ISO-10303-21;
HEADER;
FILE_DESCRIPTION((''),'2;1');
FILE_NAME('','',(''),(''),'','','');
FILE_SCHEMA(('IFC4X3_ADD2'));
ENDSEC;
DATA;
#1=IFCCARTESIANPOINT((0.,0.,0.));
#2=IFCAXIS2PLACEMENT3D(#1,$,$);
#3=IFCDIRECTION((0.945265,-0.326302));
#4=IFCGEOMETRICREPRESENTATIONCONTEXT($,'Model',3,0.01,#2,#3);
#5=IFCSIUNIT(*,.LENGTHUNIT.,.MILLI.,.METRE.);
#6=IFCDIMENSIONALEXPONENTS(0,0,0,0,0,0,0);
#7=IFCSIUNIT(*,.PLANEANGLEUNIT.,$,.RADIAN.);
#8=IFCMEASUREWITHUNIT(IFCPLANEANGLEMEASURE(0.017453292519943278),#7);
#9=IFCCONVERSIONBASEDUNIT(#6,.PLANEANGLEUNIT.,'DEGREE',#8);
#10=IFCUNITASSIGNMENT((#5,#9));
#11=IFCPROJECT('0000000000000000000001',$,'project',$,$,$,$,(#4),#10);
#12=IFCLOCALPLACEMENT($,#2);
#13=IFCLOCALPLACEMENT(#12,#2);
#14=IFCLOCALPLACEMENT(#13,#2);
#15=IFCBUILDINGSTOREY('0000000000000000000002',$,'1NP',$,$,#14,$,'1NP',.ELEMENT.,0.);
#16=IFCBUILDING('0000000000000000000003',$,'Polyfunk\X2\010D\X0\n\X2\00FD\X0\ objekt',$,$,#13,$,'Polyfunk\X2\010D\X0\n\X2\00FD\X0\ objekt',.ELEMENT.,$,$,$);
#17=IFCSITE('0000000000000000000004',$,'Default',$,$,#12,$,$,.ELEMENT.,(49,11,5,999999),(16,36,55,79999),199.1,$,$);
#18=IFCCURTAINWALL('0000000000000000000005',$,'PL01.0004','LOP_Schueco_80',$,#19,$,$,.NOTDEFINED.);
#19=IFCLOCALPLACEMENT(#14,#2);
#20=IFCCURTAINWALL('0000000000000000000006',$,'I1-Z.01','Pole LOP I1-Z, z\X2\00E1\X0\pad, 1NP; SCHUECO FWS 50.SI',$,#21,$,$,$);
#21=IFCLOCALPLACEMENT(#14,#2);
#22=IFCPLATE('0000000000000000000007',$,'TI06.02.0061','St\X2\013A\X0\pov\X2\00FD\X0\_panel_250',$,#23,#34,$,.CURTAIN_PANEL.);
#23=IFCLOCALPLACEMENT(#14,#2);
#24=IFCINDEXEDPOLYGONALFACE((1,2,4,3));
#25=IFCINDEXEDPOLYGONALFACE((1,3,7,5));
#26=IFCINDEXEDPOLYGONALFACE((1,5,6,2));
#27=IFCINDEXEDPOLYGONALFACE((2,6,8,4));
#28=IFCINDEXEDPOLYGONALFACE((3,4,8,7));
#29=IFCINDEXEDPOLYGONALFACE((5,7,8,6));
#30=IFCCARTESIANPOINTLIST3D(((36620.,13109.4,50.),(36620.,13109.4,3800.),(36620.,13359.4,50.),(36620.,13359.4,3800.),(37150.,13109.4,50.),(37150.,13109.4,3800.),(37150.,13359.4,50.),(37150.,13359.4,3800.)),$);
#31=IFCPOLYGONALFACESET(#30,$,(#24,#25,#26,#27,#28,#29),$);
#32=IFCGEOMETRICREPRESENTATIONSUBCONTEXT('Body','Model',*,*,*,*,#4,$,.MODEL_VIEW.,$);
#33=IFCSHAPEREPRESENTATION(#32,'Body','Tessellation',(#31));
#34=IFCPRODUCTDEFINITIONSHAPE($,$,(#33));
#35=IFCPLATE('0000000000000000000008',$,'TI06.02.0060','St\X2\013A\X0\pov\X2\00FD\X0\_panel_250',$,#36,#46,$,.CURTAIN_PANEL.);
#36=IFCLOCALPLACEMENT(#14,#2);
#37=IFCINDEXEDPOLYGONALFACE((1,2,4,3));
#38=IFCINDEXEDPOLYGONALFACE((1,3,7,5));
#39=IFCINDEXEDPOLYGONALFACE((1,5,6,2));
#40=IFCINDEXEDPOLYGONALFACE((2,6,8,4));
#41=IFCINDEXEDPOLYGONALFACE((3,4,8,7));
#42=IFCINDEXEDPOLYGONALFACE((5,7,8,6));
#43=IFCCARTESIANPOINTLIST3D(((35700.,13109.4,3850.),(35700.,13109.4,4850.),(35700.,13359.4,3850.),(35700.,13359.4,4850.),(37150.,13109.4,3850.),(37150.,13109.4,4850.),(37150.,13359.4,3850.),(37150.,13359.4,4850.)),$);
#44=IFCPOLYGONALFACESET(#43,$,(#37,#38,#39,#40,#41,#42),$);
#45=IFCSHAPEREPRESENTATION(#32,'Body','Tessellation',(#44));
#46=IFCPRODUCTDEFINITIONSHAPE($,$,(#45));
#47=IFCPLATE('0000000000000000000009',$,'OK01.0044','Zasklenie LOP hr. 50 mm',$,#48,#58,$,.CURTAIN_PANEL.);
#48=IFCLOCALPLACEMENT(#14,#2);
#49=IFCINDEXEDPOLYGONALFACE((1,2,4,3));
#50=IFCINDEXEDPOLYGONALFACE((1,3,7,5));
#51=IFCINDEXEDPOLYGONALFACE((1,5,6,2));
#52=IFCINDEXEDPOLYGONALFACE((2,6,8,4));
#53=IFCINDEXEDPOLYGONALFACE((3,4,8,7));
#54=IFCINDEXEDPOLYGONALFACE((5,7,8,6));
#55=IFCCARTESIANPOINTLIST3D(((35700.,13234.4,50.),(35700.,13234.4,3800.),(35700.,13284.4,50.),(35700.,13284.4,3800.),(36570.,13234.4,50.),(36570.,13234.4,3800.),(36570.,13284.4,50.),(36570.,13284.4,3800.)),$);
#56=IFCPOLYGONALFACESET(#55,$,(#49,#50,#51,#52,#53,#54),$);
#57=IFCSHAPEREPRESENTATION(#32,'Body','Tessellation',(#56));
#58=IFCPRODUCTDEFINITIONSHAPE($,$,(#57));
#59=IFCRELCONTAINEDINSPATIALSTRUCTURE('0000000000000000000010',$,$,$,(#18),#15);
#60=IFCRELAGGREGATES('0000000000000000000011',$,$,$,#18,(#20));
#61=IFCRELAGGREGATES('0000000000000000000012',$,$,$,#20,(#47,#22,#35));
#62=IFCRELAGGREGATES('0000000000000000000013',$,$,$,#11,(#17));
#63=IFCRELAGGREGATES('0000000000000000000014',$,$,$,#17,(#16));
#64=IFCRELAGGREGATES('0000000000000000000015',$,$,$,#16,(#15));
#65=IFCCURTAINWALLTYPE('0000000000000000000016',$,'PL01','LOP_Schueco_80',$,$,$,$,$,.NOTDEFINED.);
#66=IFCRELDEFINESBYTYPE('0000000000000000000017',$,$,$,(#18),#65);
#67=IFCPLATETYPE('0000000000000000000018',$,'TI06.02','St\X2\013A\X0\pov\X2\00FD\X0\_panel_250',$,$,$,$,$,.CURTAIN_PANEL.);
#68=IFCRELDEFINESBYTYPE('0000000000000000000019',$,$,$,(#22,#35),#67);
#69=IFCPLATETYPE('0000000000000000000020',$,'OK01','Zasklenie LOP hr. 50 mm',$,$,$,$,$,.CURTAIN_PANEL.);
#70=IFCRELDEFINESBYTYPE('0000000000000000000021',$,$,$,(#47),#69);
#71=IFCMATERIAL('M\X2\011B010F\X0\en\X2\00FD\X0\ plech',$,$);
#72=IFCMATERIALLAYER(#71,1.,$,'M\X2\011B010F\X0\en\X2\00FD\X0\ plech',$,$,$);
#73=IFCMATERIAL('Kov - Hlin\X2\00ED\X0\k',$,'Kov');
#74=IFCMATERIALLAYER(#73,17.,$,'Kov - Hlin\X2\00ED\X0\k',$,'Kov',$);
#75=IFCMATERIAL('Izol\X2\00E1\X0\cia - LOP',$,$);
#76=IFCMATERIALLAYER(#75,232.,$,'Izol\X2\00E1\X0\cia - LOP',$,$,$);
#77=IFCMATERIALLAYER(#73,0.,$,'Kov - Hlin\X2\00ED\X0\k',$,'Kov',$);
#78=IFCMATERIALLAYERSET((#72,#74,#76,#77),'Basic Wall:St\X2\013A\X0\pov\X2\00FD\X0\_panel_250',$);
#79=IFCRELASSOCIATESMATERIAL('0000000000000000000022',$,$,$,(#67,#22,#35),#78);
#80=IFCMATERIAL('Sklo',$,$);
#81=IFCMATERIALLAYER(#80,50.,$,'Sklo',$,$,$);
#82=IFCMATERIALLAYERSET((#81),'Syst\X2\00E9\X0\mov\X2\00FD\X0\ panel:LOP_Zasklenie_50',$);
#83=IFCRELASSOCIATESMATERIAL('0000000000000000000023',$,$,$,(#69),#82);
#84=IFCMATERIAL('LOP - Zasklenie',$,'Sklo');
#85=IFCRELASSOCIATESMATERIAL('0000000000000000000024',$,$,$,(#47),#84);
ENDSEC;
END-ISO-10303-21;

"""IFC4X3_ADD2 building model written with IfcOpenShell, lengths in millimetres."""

from ifc_helpers import new_model, entity, si_unit, converted_unit, direction, frame, frame_2d, origin, origin_2d_with_axis, place, context, subcontext, project, spatial, rectangle, extrude, source, transform, mapped, material, layer, layer_set, layer_usage, type_object, type_shapes, element, aggregate, save


model = new_model("IFC4X3_ADD2")

# Units and contexts
model_context = context("Model", 3, precision=0.01, world=origin(), true_north=direction((0.945265, -0.326302)))
body_context = subcontext(model_context, "Body", "Model", "MODEL_VIEW")
ifc_project = project(units=[si_unit("LENGTHUNIT", "METRE", prefix="MILLI"), converted_unit("PLANEANGLEUNIT", "DEGREE", entity("IfcPlaneAngleMeasure", 0.017453292519943278), si_unit("PLANEANGLEUNIT", "RADIAN"), dimensions=[0, 0, 0, 0, 0, 0, 0])], contexts=[model_context])

# Site, building, storey
site_placement = place(None, origin())
site = spatial("IfcSite", under=ifc_project, at=site_placement, Name="Default", CompositionType="ELEMENT", RefLatitude=(49, 11, 5, 999999), RefLongitude=(16, 36, 55, 79999), RefElevation=199.1)
building_placement = place(site_placement, origin())
building = spatial("IfcBuilding", under=site, at=building_placement, Name="Polyfunkčný objekt", LongName="Polyfunkčný objekt", CompositionType="ELEMENT")
storey_placement = place(building_placement, origin())
storey = spatial("IfcBuildingStorey", under=building, at=storey_placement, Name="1NP", LongName="1NP", CompositionType="ELEMENT", Elevation=0.0)

# Curtain walls, plates
curtain_wall_type = type_object("IfcCurtainWallType", Name="PL01", Description="LOP_Schueco_80", PredefinedType="NOTDEFINED")
curtain_wall_1_placement = place(storey_placement, origin())
curtain_wall_1 = element("IfcCurtainWall", 1, at=curtain_wall_1_placement, inside=storey, type_object=curtain_wall_type, Name="PL01.0004", Description="LOP_Schueco_80", PredefinedType="NOTDEFINED")
curtain_wall_2 = element("IfcCurtainWall", 2, Name="I1-Z.01", Description="Pole LOP I1-Z, západ, 1NP; SCHUECO FWS 50.SI")
aggregate(curtain_wall_1, [curtain_wall_2])
ifc_material_1 = material(Name="Měďený plech")
ifc_layer_1 = layer(ifc_material_1, 1.0, Name="Měďený plech")
ifc_material_2 = material(Name="Kov - Hliník", Category="Kov")
ifc_layer_2 = layer(ifc_material_2, 17.0, Name="Kov - Hliník", Category="Kov")
ifc_material_3 = material(Name="Izolácia - LOP")
ifc_layer_3 = layer(ifc_material_3, 232.0, Name="Izolácia - LOP")
ifc_layer_4 = layer(ifc_material_2, 0.0, Name="Kov - Hliník", Category="Kov")
ifc_layer_set_1 = layer_set([ifc_layer_1, ifc_layer_2, ifc_layer_3, ifc_layer_4], Name="Basic Wall:Stĺpový_panel_250")
ifc_layer_usage_1 = layer_usage(ifc_layer_set_1, "AXIS2", "NEGATIVE", 125.0)
plate_type_1 = type_object("IfcPlateType", Name="TI06.02", Description="Stĺpový_panel_250", PredefinedType="CURTAIN_PANEL", material=ifc_layer_set_1)
plate_1_placement = place(storey_placement, frame((36620.0, 13234.4, 50.0)))
plate_1 = element("IfcPlate", 3, at=plate_1_placement, type_object=plate_type_1, material=ifc_layer_usage_1, Name="TI06.02.0061", Description="Stĺpový_panel_250", PredefinedType="CURTAIN_PANEL", context=body_context, shape_type="SweptSolid", body=[
    extrude(rectangle(XDim=250.0, YDim=530.0, at=frame_2d((0.0, 0.0), x_axis=(1.0, 0.0))), frame((265.0, 0.0, 0.0), z_axis=(0.0, 0.0, 1.0), x_axis=(0.0, 1.0, 0.0)), (0.0, 0.0, 1.0), 3750.0),
])
ifc_layer_usage_2 = layer_usage(ifc_layer_set_1, "AXIS2", "NEGATIVE", 125.0)
plate_2_placement = place(storey_placement, frame((35700.0, 13234.4, 3850.0)))
plate_2 = element("IfcPlate", 4, at=plate_2_placement, type_object=plate_type_1, material=ifc_layer_usage_2, Name="TI06.02.0060", Description="Stĺpový_panel_250", PredefinedType="CURTAIN_PANEL", context=body_context, shape_type="SweptSolid", body=[
    extrude(rectangle(XDim=250.0, YDim=1450.0, at=origin_2d_with_axis()), frame((725.0, 0.0, 0.0), z_axis=(0.0, 0.0, 1.0), x_axis=(0.0, 1.0, 0.0)), (0.0, 0.0, 1.0), 1000.0),
])
ifc_material_4 = material(Name="LOP - Zasklenie", Category="Sklo")
ifc_material_5 = material(Name="Sklo")
ifc_layer_5 = layer(ifc_material_5, 50.0, Name="Sklo")
ifc_layer_set_2 = layer_set([ifc_layer_5], Name="Systémový panel:LOP_Zasklenie_50")
plate_type_2 = type_object("IfcPlateType", Name="OK01", Description="Zasklenie LOP hr. 50 mm", PredefinedType="CURTAIN_PANEL", material=ifc_layer_set_2)
shared_shape_1 = source(origin(), body_context, "Body", "SweptSolid", [
    extrude(rectangle(XDim=3750.0, YDim=870.0, at=frame_2d((-141.7, 0.0), x_axis=(1.0, 0.0))), frame((0.0, 0.0, 2016.7), z_axis=(0.0, 1.0, 0.0), x_axis=(0.0, 0.0, 1.0)), (0.0, 0.0, 1.0), 50.0),
])
type_shapes(plate_type_2, [shared_shape_1])
plate_3_placement = place(curtain_wall_1_placement, frame((36135.0, 13234.4, 50.0)))
plate_3 = element("IfcPlate", 5, at=plate_3_placement, type_object=plate_type_2, material=ifc_material_4, Name="OK01.0044", Description="Zasklenie LOP hr. 50 mm", PredefinedType="CURTAIN_PANEL", context=body_context, shape_type="MappedRepresentation", body=[
    mapped(shared_shape_1, transform((0.0, 0.0, 0.0), scale=1.0)),
])
aggregate(curtain_wall_2, [plate_3, plate_1, plate_2])

save(model, "model.ifc")
